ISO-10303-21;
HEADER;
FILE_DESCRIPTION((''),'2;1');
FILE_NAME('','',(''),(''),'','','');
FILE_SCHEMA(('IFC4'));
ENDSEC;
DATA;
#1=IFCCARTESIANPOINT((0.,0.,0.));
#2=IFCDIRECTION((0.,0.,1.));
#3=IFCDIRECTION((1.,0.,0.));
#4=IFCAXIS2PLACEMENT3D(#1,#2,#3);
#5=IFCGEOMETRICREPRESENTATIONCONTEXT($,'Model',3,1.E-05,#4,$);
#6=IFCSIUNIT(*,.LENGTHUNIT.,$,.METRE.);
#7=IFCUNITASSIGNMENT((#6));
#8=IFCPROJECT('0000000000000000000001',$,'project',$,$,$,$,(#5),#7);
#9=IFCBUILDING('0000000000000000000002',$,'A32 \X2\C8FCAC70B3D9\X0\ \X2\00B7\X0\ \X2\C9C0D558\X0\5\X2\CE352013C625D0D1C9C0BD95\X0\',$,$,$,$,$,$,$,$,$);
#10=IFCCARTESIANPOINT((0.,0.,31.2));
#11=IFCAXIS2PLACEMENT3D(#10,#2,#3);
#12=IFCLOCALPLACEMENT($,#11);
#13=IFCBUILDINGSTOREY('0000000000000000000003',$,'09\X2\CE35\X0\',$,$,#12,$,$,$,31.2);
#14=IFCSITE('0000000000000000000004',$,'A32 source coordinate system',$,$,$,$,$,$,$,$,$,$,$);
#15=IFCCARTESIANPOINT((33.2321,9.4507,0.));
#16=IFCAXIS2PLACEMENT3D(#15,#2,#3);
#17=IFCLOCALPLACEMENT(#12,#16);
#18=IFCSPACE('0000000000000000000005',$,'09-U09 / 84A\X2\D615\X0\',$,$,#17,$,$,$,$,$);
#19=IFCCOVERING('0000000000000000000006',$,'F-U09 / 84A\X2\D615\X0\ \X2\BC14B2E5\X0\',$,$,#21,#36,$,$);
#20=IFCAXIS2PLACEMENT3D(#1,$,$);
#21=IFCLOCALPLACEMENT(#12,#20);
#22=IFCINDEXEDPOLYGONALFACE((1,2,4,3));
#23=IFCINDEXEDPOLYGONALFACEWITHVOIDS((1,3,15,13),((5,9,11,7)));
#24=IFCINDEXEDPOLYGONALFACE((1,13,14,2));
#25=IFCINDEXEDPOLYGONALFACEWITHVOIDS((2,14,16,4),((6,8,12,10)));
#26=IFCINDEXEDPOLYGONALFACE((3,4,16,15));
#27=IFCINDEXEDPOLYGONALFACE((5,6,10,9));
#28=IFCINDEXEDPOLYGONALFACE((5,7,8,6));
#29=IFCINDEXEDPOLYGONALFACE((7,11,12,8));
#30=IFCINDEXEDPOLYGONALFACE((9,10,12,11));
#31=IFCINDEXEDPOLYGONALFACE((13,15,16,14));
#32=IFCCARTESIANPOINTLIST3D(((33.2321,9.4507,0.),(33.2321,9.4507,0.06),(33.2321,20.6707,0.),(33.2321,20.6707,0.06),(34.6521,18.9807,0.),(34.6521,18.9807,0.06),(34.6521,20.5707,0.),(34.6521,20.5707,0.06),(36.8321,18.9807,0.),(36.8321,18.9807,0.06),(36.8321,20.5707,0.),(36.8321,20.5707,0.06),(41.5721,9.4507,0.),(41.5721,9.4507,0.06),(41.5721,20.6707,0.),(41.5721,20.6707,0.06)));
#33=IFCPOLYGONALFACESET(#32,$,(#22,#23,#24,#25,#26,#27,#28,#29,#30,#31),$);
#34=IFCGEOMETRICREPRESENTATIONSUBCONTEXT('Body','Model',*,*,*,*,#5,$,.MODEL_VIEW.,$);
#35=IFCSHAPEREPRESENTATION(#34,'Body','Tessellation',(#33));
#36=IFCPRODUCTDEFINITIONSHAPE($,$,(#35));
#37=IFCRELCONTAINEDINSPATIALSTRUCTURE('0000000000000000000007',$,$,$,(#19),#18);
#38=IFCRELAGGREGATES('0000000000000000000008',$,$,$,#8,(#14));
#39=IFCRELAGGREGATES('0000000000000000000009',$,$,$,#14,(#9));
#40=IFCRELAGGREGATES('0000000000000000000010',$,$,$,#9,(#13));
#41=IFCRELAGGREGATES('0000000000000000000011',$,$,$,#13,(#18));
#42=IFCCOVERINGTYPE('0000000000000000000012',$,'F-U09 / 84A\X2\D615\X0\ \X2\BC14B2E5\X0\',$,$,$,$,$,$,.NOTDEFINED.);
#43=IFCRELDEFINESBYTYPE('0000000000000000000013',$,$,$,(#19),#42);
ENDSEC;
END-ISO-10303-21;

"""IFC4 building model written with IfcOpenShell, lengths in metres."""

from ifc_helpers import new_model, si_unit, frame, origin, origin_with_axes, place, context, subcontext, project, spatial, polyline, outline, extrude, source, transform, mapped, type_object, type_shapes, element, save


model = new_model("IFC4")

# Units and contexts
model_context = context("Model", 3, precision=1e-05, world=origin_with_axes())
body_context = subcontext(model_context, "Body", "Model", "MODEL_VIEW")
ifc_project = project(units=[si_unit("LENGTHUNIT", "METRE")], contexts=[model_context])

# Site, building, storey, space
storey_placement = place(None, frame((0.0, 0.0, 31.2), z_axis=(0.0, 0.0, 1.0), x_axis=(1.0, 0.0, 0.0)))
space_placement = place(storey_placement, frame((33.2321, 9.4507, 0.0), z_axis=(0.0, 0.0, 1.0), x_axis=(1.0, 0.0, 0.0)))
site = spatial("IfcSite", under=ifc_project, Name="A32 source coordinate system")
building = spatial("IfcBuilding", under=site, Name="A32 주거동 · 지하5층–옥탑지붕")
storey = spatial("IfcBuildingStorey", under=building, at=storey_placement, Name="09층", Elevation=31.2)
space = spatial("IfcSpace", under=storey, at=space_placement, Name="09-U09 / 84A형")

# Covering
covering_type_1 = type_object("IfcCoveringType", Name="F-U09 / 84A형 바닥", PredefinedType="NOTDEFINED")
shared_shape_1 = source(origin(), body_context, "Body", "SweptSolid", [
    extrude(outline(polyline([(0.0, 0.0), (0.0, 11.22), (8.34, 11.22), (8.34, 0.0), (0.0, 0.0)]), holes=[polyline([(1.42, 11.12), (1.42, 9.53), (3.6, 9.53), (3.6, 11.12), (1.42, 11.12)])]), origin(), (0.0, 0.0, 1.0), 0.06),
])
type_shapes(covering_type_1, [shared_shape_1])
covering_1_placement = place(space_placement, origin_with_axes())
element("IfcCovering", 1, at=covering_1_placement, inside=space, type_object=covering_type_1, Name="F-U09 / 84A형 바닥", context=body_context, shape_type="MappedRepresentation", body=[
    mapped(shared_shape_1, transform((0.0, 0.0, 0.0), scale=1.0)),
])

save(model, "model.ifc")
